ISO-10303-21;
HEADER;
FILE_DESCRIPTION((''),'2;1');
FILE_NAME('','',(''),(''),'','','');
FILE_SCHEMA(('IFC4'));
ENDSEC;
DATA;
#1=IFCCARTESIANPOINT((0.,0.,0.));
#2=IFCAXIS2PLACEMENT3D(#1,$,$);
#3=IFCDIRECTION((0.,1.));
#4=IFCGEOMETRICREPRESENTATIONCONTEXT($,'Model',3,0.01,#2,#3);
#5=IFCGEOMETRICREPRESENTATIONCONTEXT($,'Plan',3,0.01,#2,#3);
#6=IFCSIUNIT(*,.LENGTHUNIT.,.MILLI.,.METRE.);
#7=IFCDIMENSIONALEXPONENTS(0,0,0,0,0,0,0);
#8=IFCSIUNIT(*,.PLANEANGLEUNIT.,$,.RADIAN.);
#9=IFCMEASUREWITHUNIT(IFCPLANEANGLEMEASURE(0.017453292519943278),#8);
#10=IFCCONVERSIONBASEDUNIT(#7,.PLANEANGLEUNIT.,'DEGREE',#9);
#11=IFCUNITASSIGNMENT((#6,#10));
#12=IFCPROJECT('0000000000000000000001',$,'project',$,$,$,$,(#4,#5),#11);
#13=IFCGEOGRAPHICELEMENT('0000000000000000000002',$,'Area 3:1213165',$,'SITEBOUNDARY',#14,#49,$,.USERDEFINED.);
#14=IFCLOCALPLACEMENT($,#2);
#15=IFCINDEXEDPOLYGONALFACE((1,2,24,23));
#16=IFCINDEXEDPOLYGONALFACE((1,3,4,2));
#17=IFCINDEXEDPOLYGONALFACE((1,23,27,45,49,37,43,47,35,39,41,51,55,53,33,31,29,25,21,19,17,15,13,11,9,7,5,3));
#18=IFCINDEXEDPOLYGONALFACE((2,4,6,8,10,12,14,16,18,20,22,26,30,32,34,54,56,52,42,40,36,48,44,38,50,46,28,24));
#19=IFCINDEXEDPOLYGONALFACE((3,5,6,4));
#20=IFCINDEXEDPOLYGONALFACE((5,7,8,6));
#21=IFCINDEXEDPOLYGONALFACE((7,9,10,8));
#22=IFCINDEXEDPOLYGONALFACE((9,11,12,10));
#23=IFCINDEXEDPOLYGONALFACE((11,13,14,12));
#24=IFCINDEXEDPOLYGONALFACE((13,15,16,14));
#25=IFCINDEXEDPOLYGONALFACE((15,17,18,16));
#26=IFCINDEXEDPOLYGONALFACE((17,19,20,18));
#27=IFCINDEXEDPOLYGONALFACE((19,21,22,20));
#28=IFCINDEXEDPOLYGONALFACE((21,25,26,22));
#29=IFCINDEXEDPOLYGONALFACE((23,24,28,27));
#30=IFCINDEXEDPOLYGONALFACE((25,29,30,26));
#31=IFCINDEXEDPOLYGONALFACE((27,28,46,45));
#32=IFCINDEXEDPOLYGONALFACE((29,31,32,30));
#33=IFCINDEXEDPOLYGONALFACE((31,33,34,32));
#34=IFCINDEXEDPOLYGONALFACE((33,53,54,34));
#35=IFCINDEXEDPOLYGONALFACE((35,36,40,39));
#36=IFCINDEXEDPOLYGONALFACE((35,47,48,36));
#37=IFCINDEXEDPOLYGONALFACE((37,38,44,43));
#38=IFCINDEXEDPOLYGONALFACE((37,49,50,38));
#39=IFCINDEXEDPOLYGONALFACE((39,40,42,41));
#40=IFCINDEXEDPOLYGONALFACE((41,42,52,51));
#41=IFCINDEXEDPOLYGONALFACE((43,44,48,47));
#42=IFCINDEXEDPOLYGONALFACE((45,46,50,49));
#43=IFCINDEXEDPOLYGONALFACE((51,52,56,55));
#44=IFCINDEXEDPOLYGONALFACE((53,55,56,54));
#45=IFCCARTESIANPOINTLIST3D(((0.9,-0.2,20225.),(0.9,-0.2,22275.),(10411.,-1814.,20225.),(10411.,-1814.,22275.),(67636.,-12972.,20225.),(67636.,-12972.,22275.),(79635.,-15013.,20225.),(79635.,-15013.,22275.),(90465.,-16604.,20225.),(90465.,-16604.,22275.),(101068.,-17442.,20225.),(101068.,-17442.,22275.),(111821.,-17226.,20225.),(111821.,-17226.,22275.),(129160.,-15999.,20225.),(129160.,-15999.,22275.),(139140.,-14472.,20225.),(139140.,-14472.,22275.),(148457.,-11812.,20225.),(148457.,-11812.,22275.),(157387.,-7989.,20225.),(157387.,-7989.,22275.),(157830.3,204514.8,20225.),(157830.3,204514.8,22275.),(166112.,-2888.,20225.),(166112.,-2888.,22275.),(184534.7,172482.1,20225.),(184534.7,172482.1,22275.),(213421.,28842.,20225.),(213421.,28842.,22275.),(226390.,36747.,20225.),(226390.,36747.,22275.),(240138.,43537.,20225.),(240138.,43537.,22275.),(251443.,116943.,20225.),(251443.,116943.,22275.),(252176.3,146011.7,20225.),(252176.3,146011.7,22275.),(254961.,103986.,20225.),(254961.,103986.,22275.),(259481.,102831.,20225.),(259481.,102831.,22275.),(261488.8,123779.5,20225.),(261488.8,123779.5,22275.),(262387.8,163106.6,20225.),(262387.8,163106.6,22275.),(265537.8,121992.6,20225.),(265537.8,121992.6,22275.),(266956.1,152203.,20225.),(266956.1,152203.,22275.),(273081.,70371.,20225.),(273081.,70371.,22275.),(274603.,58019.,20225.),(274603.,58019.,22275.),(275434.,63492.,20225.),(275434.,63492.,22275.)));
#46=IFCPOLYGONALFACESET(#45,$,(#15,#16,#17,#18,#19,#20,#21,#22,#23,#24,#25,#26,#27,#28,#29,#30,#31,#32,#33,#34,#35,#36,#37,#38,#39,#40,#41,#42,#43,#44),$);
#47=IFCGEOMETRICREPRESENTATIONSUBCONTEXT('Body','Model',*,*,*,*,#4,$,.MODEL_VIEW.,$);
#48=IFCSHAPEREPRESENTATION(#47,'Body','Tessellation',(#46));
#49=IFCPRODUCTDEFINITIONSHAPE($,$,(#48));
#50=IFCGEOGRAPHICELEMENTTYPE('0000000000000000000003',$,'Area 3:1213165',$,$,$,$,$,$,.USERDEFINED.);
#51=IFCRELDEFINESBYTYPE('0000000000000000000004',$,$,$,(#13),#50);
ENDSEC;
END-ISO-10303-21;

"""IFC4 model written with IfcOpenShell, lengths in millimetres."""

from ifc_helpers import new_model, entity, si_unit, converted_unit, direction, frame, origin, place, context, subcontext, project, indexed_curve, outline, extrude, type_object, element, save


model = new_model("IFC4")

# Units and contexts
model_context = context("Model", 3, precision=0.01, world=origin(), true_north=direction((0.0, 1.0)))
plan_context = context("Plan", 3, precision=0.01, world=origin(), true_north=direction((0.0, 1.0)))
body_context = subcontext(model_context, "Body", "Model", "MODEL_VIEW")
ifc_project = project(units=[si_unit("LENGTHUNIT", "METRE", prefix="MILLI"), converted_unit("PLANEANGLEUNIT", "DEGREE", entity("IfcPlaneAngleMeasure", 0.017453292519943278), si_unit("PLANEANGLEUNIT", "RADIAN"), dimensions=[0, 0, 0, 0, 0, 0, 0])], contexts=[model_context, plan_context])

# Geographic element
geographic_element_type = type_object("IfcGeographicElementType", Name="Area 3:1213165", PredefinedType="USERDEFINED")
placement_1 = place(None, origin())
placement_2 = place(placement_1, origin())
placement_3 = place(placement_2, frame((0.0, 0.0, 20225.0)))
geographic_element_placement = place(placement_3, origin())
element("IfcGeographicElement", 1, at=geographic_element_placement, type_object=geographic_element_type, Name="Area 3:1213165", ObjectType="SITEBOUNDARY", PredefinedType="USERDEFINED", context=body_context, shape_type="SweptSolid", body=[
    extrude(outline(indexed_curve([(10411.0, -1814.0), (67636.0, -12972.0), (79635.0, -15013.0), (90465.0, -16604.0), (101068.0, -17442.0), (111821.0, -17226.0), (129160.0, -15999.0), (139140.0, -14472.0), (148457.0, -11812.0), (157387.0, -7989.0), (166112.0, -2888.0), (213421.0, 28842.0), (226390.0, 36747.0), (240138.0, 43537.0), (274603.0, 58019.0), (275434.0, 63492.0), (273081.0, 70371.0), (259481.0, 102831.0), (254961.0, 103986.0), (251443.0, 116943.0), (265537.8, 121992.6), (261488.8, 123779.5), (252176.3, 146011.7), (266956.1, 152203.0), (262387.8, 163106.6), (184534.7, 172482.1), (157830.3, 204514.8), (0.9, -0.2), (10411.0, -1814.0)], self_intersect=False)), origin(), (0.0, 0.0, 1.0), 2050.0),
])

save(model, "model.ifc")
